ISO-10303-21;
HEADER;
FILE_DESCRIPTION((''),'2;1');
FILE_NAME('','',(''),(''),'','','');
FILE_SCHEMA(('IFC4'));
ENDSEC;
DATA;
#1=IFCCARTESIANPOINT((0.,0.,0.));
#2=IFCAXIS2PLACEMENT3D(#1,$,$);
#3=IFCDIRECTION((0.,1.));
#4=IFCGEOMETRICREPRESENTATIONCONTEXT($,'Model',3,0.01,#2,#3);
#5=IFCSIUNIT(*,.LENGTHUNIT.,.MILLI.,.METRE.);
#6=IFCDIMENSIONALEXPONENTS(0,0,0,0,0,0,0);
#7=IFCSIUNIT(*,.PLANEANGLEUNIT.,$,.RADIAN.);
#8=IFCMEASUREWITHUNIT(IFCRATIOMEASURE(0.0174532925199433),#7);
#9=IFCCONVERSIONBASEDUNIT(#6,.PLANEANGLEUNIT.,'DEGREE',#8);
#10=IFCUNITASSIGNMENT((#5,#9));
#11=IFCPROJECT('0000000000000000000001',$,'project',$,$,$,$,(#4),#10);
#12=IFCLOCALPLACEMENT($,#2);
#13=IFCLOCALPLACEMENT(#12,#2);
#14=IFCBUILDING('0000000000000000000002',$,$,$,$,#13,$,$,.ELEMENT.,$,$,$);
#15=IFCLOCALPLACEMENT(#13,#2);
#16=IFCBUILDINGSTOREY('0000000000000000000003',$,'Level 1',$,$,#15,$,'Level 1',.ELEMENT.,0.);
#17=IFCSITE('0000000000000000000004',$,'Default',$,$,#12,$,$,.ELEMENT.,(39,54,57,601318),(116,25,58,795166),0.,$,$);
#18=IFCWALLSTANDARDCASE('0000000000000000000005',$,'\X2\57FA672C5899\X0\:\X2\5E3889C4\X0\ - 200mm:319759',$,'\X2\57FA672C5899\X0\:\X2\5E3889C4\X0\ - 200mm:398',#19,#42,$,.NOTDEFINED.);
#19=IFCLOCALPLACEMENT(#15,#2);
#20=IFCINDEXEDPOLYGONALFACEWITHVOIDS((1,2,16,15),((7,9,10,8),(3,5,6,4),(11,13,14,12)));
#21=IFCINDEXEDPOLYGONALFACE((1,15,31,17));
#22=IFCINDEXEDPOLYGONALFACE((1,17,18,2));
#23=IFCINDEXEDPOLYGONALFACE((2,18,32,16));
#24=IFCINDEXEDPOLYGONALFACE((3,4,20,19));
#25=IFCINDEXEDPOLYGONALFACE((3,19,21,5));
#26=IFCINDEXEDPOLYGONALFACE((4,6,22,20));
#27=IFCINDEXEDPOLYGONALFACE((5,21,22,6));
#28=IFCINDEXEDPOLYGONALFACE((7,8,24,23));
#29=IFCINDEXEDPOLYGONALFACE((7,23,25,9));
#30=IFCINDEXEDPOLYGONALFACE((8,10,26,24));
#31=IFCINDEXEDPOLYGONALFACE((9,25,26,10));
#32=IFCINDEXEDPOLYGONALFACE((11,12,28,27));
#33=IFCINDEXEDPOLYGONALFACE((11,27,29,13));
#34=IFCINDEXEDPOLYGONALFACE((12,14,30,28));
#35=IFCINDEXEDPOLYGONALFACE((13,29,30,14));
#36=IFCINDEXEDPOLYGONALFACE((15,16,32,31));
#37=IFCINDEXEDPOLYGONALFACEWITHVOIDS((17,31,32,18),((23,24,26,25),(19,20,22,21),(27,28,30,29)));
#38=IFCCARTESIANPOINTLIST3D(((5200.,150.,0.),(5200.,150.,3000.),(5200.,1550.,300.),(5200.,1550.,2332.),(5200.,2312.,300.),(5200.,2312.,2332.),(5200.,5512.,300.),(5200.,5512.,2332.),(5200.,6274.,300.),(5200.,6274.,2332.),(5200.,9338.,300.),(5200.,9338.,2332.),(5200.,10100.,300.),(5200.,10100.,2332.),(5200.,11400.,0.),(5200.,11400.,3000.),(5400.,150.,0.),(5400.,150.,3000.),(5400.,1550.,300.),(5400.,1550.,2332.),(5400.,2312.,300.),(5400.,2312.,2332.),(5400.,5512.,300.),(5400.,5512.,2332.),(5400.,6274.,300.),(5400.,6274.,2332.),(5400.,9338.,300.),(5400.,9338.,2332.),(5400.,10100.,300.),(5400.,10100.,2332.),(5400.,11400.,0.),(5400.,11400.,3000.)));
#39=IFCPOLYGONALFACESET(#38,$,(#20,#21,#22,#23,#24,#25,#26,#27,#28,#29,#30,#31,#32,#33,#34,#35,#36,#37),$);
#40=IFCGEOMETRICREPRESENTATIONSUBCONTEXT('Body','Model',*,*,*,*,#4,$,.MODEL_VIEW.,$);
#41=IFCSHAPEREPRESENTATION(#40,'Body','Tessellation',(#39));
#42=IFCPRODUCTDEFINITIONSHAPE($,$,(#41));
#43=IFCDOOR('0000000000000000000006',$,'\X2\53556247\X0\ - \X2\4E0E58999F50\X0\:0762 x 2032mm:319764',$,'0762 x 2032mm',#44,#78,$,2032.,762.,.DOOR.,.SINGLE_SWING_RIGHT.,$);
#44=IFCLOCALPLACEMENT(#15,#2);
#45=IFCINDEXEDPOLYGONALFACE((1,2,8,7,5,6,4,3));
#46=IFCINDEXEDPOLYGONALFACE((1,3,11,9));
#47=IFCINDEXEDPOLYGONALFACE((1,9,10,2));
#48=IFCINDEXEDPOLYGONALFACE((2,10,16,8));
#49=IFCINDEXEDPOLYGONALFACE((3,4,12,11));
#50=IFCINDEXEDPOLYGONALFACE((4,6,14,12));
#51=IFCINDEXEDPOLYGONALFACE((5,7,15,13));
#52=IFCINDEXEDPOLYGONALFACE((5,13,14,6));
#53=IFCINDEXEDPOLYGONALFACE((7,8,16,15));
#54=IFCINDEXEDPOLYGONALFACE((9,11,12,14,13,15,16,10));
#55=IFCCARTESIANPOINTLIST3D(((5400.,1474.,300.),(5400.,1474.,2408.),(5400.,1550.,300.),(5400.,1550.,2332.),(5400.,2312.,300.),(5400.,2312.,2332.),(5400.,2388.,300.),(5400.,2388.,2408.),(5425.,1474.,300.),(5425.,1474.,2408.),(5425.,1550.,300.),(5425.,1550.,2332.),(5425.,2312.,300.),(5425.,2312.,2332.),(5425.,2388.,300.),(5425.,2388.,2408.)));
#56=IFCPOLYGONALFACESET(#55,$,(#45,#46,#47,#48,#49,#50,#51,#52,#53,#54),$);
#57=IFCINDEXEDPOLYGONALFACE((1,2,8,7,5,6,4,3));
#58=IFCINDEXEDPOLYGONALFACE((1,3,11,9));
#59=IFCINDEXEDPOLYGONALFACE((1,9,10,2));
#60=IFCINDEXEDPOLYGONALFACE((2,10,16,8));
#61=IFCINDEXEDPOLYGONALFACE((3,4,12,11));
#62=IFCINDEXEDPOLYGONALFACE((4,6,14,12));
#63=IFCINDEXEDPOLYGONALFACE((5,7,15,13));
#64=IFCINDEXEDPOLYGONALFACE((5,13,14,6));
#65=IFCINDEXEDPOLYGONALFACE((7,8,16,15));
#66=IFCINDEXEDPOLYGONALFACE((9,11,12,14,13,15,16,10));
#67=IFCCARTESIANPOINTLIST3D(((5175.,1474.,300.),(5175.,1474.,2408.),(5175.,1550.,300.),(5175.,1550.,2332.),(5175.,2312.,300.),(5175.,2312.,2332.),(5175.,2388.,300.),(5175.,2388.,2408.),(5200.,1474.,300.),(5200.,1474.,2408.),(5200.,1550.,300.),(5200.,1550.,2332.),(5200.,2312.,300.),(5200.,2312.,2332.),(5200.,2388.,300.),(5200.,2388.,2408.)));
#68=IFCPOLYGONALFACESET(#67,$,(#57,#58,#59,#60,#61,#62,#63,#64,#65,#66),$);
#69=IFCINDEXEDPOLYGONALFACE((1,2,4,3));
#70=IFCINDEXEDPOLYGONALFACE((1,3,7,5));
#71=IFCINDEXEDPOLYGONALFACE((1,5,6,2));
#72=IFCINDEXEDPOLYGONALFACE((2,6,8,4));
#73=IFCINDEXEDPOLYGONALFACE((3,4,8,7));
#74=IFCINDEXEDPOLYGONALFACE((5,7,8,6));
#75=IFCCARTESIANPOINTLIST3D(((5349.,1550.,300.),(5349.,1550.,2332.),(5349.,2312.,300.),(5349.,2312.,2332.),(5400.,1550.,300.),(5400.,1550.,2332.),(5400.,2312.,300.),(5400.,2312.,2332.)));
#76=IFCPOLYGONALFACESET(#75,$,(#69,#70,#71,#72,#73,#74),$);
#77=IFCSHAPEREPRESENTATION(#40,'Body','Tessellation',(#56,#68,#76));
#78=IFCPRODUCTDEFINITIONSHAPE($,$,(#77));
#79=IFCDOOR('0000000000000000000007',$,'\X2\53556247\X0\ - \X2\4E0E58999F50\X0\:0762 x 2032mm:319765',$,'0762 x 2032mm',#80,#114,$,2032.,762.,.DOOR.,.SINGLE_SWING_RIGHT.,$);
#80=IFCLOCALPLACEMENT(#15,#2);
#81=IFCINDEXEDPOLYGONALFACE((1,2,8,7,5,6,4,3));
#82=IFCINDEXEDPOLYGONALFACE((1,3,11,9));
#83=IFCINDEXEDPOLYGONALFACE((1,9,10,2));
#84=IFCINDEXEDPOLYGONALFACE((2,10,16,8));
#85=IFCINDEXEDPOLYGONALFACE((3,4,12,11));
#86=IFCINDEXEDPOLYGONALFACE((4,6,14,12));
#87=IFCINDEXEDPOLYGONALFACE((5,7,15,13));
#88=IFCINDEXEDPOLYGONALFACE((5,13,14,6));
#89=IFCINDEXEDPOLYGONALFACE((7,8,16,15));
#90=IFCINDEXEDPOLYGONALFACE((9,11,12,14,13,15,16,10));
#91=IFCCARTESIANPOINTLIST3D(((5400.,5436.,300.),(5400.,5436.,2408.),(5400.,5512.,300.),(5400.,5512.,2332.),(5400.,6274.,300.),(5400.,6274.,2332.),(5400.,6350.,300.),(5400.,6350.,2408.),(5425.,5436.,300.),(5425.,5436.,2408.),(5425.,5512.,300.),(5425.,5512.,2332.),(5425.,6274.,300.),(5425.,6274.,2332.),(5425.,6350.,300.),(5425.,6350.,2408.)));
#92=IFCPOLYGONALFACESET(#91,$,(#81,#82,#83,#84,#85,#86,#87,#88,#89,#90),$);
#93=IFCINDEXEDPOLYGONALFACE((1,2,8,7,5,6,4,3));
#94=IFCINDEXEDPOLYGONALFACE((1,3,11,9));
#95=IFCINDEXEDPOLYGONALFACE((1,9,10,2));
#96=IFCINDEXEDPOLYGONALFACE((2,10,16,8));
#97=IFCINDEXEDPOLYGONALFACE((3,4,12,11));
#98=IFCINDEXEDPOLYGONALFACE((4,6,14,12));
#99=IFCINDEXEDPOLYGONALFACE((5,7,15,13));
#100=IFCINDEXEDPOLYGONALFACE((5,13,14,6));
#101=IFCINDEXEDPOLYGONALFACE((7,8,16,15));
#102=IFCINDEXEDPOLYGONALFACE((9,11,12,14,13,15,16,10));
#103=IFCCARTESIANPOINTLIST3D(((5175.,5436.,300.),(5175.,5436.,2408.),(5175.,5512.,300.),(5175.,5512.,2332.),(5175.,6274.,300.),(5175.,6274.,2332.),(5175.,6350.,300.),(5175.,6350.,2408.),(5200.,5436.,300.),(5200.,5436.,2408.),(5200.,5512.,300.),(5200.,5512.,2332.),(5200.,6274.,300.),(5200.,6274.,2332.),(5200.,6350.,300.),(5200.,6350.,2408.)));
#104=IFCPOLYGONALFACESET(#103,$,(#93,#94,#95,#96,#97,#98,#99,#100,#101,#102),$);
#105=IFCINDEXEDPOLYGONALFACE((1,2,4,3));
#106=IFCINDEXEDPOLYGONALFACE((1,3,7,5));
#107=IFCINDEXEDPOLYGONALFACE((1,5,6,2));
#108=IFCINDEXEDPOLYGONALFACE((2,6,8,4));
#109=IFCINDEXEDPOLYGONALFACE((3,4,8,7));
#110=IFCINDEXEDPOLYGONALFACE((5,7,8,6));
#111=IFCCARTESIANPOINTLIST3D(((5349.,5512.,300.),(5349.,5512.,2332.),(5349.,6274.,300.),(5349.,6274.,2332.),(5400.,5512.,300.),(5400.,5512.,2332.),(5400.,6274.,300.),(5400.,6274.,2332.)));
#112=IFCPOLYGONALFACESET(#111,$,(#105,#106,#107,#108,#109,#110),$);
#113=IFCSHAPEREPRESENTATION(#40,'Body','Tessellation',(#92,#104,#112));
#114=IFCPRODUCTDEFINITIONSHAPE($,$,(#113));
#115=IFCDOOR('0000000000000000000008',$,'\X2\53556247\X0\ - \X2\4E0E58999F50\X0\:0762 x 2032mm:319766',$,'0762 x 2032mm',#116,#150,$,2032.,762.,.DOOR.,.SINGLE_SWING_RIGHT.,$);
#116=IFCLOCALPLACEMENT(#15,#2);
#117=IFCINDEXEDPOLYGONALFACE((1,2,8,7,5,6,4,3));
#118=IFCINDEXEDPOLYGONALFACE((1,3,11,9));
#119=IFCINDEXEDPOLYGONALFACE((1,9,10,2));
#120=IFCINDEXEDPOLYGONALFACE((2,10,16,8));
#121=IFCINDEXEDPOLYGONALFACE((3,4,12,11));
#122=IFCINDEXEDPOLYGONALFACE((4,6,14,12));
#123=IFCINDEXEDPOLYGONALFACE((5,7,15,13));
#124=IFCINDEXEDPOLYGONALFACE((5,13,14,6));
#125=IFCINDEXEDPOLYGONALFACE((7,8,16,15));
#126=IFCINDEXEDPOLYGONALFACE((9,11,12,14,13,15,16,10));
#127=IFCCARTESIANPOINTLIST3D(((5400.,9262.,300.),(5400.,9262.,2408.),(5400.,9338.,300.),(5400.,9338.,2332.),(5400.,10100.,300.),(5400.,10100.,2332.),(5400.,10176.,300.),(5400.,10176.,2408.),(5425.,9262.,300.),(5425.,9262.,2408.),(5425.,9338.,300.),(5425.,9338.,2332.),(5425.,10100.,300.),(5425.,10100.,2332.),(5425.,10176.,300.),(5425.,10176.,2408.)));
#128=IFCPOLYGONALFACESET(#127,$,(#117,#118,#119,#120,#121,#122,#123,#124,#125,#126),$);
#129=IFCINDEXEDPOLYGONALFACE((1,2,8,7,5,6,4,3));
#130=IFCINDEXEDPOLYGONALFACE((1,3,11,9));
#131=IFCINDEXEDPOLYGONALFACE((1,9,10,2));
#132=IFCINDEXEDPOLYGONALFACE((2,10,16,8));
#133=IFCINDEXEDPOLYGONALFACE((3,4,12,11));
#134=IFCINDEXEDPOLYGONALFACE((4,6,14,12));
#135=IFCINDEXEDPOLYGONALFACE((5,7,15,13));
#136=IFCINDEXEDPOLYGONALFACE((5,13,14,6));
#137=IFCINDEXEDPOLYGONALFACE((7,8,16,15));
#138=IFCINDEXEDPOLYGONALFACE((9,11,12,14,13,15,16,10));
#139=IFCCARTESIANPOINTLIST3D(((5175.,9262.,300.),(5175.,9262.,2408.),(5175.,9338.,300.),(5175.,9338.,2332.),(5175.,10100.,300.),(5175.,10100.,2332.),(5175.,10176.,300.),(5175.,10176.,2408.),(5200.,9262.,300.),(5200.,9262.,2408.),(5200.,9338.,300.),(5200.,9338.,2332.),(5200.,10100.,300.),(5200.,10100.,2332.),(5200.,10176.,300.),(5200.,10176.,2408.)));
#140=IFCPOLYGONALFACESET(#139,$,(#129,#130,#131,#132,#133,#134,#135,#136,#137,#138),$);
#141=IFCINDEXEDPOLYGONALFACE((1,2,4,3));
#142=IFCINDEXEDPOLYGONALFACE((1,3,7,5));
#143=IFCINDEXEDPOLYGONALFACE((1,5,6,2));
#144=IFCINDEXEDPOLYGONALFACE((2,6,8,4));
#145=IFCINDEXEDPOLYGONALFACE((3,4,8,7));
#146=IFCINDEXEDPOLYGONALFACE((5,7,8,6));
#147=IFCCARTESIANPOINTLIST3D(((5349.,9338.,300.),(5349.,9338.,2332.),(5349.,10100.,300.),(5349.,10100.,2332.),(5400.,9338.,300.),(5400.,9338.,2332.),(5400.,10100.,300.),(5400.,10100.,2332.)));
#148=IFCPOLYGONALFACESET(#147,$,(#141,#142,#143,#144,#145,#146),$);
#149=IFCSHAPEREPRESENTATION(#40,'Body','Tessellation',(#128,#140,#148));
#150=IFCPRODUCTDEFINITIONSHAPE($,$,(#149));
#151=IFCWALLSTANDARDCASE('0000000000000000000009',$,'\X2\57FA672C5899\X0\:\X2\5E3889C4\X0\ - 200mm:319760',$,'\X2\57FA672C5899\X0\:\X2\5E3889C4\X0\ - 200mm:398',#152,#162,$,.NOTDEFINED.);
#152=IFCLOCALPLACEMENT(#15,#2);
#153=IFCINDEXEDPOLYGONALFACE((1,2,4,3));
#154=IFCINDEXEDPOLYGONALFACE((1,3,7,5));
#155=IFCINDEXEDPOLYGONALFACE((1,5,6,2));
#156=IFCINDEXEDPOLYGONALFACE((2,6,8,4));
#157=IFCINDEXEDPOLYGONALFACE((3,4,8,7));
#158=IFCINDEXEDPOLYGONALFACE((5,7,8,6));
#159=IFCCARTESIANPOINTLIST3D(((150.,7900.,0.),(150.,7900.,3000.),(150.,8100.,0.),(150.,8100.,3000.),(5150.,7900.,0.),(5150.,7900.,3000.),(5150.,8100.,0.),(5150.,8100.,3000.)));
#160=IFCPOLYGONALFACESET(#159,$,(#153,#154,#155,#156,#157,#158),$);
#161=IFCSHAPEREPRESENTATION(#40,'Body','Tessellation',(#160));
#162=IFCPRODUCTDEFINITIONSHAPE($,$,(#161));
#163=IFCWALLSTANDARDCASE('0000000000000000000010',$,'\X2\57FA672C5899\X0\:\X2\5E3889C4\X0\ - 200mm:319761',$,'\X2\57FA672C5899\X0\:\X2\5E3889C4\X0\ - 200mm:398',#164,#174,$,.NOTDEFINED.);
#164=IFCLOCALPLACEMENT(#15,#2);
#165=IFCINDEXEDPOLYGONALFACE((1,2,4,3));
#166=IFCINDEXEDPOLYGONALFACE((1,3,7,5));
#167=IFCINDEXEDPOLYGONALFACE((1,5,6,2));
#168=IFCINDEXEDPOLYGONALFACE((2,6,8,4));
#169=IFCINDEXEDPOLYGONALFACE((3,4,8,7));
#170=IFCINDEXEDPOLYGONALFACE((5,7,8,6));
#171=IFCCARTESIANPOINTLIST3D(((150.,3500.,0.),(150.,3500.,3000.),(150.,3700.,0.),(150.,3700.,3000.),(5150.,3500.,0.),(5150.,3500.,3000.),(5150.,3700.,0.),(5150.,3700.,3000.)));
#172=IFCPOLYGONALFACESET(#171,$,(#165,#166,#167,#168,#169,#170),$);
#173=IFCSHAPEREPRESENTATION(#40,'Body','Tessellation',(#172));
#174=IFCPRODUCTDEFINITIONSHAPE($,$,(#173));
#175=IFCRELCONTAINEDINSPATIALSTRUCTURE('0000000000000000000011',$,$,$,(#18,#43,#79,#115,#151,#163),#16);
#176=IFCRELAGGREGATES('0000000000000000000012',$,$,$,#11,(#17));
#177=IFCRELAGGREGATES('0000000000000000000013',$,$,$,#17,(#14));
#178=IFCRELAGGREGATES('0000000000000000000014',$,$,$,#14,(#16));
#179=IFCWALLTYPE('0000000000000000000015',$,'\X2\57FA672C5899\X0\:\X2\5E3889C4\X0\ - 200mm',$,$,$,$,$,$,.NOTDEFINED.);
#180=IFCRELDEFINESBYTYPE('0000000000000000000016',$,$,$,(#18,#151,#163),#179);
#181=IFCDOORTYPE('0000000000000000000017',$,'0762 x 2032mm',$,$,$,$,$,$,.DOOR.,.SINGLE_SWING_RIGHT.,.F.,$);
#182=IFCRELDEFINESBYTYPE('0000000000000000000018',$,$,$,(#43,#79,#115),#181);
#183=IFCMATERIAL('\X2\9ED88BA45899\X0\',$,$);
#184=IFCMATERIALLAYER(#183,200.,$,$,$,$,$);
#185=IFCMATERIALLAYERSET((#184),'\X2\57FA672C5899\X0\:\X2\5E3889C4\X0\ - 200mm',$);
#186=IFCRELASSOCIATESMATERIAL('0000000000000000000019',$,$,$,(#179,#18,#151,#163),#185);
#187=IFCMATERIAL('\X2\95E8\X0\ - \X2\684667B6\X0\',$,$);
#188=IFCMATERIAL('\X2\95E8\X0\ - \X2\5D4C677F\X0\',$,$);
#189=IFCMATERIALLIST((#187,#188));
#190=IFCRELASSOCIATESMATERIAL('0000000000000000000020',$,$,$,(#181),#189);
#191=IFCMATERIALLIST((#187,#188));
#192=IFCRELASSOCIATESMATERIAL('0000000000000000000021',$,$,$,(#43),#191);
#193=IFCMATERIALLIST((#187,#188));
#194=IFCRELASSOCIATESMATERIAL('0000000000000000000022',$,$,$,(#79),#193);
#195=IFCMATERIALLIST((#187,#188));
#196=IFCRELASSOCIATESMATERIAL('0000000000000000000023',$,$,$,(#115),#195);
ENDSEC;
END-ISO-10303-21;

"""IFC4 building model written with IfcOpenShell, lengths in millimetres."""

from ifc_helpers import new_model, entity, si_unit, converted_unit, direction, frame, frame_2d, origin, place, context, subcontext, project, spatial, polyline, rectangle, outline, extrude, source, transform, mapped, material, material_list, layer, layer_set, layer_usage, type_object, type_shapes, element, fill, save


model = new_model("IFC4")

# Units and contexts
model_context = context("Model", 3, precision=0.01, world=origin(), true_north=direction((0.0, 1.0)))
body_context = subcontext(model_context, "Body", "Model", "MODEL_VIEW")
ifc_project = project(units=[si_unit("LENGTHUNIT", "METRE", prefix="MILLI"), converted_unit("PLANEANGLEUNIT", "DEGREE", entity("IfcRatioMeasure", 0.0174532925199433), si_unit("PLANEANGLEUNIT", "RADIAN"), dimensions=[0, 0, 0, 0, 0, 0, 0])], contexts=[model_context])

# Site, building, storey
site_placement = place(None, origin())
site = spatial("IfcSite", under=ifc_project, at=site_placement, Name="Default", CompositionType="ELEMENT", RefLatitude=(39, 54, 57, 601318), RefLongitude=(116, 25, 58, 795166), RefElevation=0.0)
building_placement = place(site_placement, origin())
building = spatial("IfcBuilding", under=site, at=building_placement, CompositionType="ELEMENT")
storey_placement = place(building_placement, origin())
storey = spatial("IfcBuildingStorey", under=building, at=storey_placement, Name="Level 1", LongName="Level 1", CompositionType="ELEMENT", Elevation=0.0)

# Shared definitions
ifc_material_1 = material(Name="默认墙")
ifc_layer = layer(ifc_material_1, 200.0)
ifc_layer_set = layer_set([ifc_layer], Name="基本墙:常规 - 200mm")
wall_type = type_object("IfcWallType", Name="基本墙:常规 - 200mm", PredefinedType="NOTDEFINED", material=ifc_layer_set)

# Wall, openings, doors
ifc_layer_usage_1 = layer_usage(ifc_layer_set, "AXIS2", "NEGATIVE", 100.0)
wall_1_placement = place(storey_placement, frame((5300.0, 11400.0, 0.0), z_axis=(0.0, 0.0, 1.0), x_axis=(0.0, -1.0, 0.0)))
wall_1 = element("IfcWallStandardCase", 1, at=wall_1_placement, inside=storey, type_object=wall_type, material=ifc_layer_usage_1, Name="基本墙:常规 - 200mm:319759", ObjectType="基本墙:常规 - 200mm:398", PredefinedType="NOTDEFINED", context=body_context, shape_type="SweptSolid", body=[
    extrude(rectangle(XDim=11250.0, YDim=200.0, at=frame_2d((5625.0, 0.0), x_axis=(-1.0, 0.0))), origin(), (0.0, 0.0, 1.0), 3000.0),
])
opening_1_placement = place(wall_1_placement, frame((9088.0, -100.0, 300.0)))
opening_1 = element("IfcOpeningElement", 2, at=opening_1_placement, cuts=wall_1, ObjectType="Opening", PredefinedType="OPENING", context=body_context, shape_type="SweptSolid", body=[
    extrude(rectangle(XDim=762.0, YDim=2032.0, at=frame_2d((1016.0, 381.0), x_axis=(0.0, 1.0))), frame((0.0, 0.0, 0.0), z_axis=(0.0, 1.0, 0.0), x_axis=(0.0, 0.0, 1.0)), (0.0, 0.0, 1.0), 200.0),
])
opening_2_placement = place(wall_1_placement, frame((5126.0, -100.0, 300.0)))
opening_2 = element("IfcOpeningElement", 3, at=opening_2_placement, cuts=wall_1, ObjectType="Opening", PredefinedType="OPENING", context=body_context, shape_type="SweptSolid", body=[
    extrude(rectangle(XDim=762.0, YDim=2032.0, at=frame_2d((1016.0, 381.0), x_axis=(0.0, 1.0))), frame((0.0, 0.0, 0.0), z_axis=(0.0, 1.0, 0.0), x_axis=(0.0, 0.0, 1.0)), (0.0, 0.0, 1.0), 200.0),
])
opening_3_placement = place(wall_1_placement, frame((1300.0, -100.0, 300.0)))
opening_3 = element("IfcOpeningElement", 4, at=opening_3_placement, cuts=wall_1, ObjectType="Opening", PredefinedType="OPENING", context=body_context, shape_type="SweptSolid", body=[
    extrude(rectangle(XDim=762.0, YDim=2032.0, at=frame_2d((1016.0, 381.0), x_axis=(0.0, 1.0))), frame((0.0, 0.0, 0.0), z_axis=(0.0, 1.0, 0.0), x_axis=(0.0, 0.0, 1.0)), (0.0, 0.0, 1.0), 200.0),
])
ifc_material_2 = material(Name="门 - 框架")
ifc_material_3 = material(Name="门 - 嵌板")
ifc_material_list_1 = material_list([ifc_material_2, ifc_material_3])
ifc_material_list_2 = material_list([ifc_material_2, ifc_material_3])
door_type_1 = type_object("IfcDoorType", Name="0762 x 2032mm", OperationType="SINGLE_SWING_RIGHT", ParameterTakesPrecedence=False, PredefinedType="DOOR", material=ifc_material_list_2)
shared_shape_1 = source(origin(), body_context, "Body", "SweptSolid", [
    extrude(outline(polyline([(-457.0, -1073.0), (457.0, -1073.0), (457.0, 1035.0), (381.0, 1035.0), (381.0, -997.0), (-381.0, -997.0), (-381.0, 1035.0), (-457.0, 1035.0), (-457.0, -1073.0)])), frame((381.0, 200.0, 1035.0), z_axis=(0.0, 1.0, 0.0), x_axis=(1.0, 0.0, 0.0)), (0.0, 0.0, 1.0), 25.0),
    extrude(outline(polyline([(-1073.0, -457.0), (1035.0, -457.0), (1035.0, -381.0), (-997.0, -381.0), (-997.0, 381.0), (1035.0, 381.0), (1035.0, 457.0), (-1073.0, 457.0), (-1073.0, -457.0)])), frame((381.0, -25.0, 1035.0), z_axis=(0.0, 1.0, 0.0), x_axis=(0.0, 0.0, -1.0)), (0.0, 0.0, 1.0), 25.0),
    extrude(rectangle(XDim=51.0, YDim=762.0, at=frame_2d((0.0, 0.0), x_axis=(1.0, 0.0))), frame((381.0, 174.5, 0.0), z_axis=(0.0, 0.0, 1.0), x_axis=(0.0, 1.0, 0.0)), (0.0, 0.0, 1.0), 2032.0),
])
type_shapes(door_type_1, [shared_shape_1])
door_1_placement = place(opening_1_placement, origin())
door_1 = element("IfcDoor", 5, at=door_1_placement, inside=storey, type_object=door_type_1, material=ifc_material_list_1, Name="单扇 - 与墙齐:0762 x 2032mm:319764", ObjectType="0762 x 2032mm", OperationType="SINGLE_SWING_RIGHT", OverallHeight=2032.0, OverallWidth=762.0, PredefinedType="DOOR", context=body_context, shape_type="MappedRepresentation", body=[
    mapped(shared_shape_1, transform((0.0, 0.0, 0.0), scale=1.0)),
])
fill(opening_1, door_1)
ifc_material_list_3 = material_list([ifc_material_2, ifc_material_3])
door_2_placement = place(opening_2_placement, origin())
door_2 = element("IfcDoor", 6, at=door_2_placement, inside=storey, type_object=door_type_1, material=ifc_material_list_3, Name="单扇 - 与墙齐:0762 x 2032mm:319765", ObjectType="0762 x 2032mm", OperationType="SINGLE_SWING_RIGHT", OverallHeight=2032.0, OverallWidth=762.0, PredefinedType="DOOR", context=body_context, shape_type="MappedRepresentation", body=[
    mapped(shared_shape_1, transform((0.0, 0.0, 0.0), scale=1.0)),
])
fill(opening_2, door_2)
ifc_material_list_4 = material_list([ifc_material_2, ifc_material_3])
door_3_placement = place(opening_3_placement, origin())
door_3 = element("IfcDoor", 7, at=door_3_placement, inside=storey, type_object=door_type_1, material=ifc_material_list_4, Name="单扇 - 与墙齐:0762 x 2032mm:319766", ObjectType="0762 x 2032mm", OperationType="SINGLE_SWING_RIGHT", OverallHeight=2032.0, OverallWidth=762.0, PredefinedType="DOOR", context=body_context, shape_type="MappedRepresentation", body=[
    mapped(shared_shape_1, transform((0.0, 0.0, 0.0), scale=1.0)),
])
fill(opening_3, door_3)

# Walls
ifc_layer_usage_2 = layer_usage(ifc_layer_set, "AXIS2", "NEGATIVE", 100.0)
wall_2_placement = place(storey_placement, frame((150.0, 8000.0, 0.0)))
element("IfcWallStandardCase", 8, at=wall_2_placement, inside=storey, type_object=wall_type, material=ifc_layer_usage_2, Name="基本墙:常规 - 200mm:319760", ObjectType="基本墙:常规 - 200mm:398", PredefinedType="NOTDEFINED", context=body_context, shape_type="SweptSolid", body=[
    extrude(rectangle(XDim=5000.0, YDim=200.0, at=frame_2d((2500.0, 0.0), x_axis=(-1.0, 0.0))), origin(), (0.0, 0.0, 1.0), 3000.0),
])
ifc_layer_usage_3 = layer_usage(ifc_layer_set, "AXIS2", "NEGATIVE", 100.0)
wall_3_placement = place(storey_placement, frame((150.0, 3600.0, 0.0)))
element("IfcWallStandardCase", 9, at=wall_3_placement, inside=storey, type_object=wall_type, material=ifc_layer_usage_3, Name="基本墙:常规 - 200mm:319761", ObjectType="基本墙:常规 - 200mm:398", PredefinedType="NOTDEFINED", context=body_context, shape_type="SweptSolid", body=[
    extrude(rectangle(XDim=5000.0, YDim=200.0, at=frame_2d((2500.0, 0.0), x_axis=(-1.0, 0.0))), origin(), (0.0, 0.0, 1.0), 3000.0),
])

save(model, "model.ifc")
